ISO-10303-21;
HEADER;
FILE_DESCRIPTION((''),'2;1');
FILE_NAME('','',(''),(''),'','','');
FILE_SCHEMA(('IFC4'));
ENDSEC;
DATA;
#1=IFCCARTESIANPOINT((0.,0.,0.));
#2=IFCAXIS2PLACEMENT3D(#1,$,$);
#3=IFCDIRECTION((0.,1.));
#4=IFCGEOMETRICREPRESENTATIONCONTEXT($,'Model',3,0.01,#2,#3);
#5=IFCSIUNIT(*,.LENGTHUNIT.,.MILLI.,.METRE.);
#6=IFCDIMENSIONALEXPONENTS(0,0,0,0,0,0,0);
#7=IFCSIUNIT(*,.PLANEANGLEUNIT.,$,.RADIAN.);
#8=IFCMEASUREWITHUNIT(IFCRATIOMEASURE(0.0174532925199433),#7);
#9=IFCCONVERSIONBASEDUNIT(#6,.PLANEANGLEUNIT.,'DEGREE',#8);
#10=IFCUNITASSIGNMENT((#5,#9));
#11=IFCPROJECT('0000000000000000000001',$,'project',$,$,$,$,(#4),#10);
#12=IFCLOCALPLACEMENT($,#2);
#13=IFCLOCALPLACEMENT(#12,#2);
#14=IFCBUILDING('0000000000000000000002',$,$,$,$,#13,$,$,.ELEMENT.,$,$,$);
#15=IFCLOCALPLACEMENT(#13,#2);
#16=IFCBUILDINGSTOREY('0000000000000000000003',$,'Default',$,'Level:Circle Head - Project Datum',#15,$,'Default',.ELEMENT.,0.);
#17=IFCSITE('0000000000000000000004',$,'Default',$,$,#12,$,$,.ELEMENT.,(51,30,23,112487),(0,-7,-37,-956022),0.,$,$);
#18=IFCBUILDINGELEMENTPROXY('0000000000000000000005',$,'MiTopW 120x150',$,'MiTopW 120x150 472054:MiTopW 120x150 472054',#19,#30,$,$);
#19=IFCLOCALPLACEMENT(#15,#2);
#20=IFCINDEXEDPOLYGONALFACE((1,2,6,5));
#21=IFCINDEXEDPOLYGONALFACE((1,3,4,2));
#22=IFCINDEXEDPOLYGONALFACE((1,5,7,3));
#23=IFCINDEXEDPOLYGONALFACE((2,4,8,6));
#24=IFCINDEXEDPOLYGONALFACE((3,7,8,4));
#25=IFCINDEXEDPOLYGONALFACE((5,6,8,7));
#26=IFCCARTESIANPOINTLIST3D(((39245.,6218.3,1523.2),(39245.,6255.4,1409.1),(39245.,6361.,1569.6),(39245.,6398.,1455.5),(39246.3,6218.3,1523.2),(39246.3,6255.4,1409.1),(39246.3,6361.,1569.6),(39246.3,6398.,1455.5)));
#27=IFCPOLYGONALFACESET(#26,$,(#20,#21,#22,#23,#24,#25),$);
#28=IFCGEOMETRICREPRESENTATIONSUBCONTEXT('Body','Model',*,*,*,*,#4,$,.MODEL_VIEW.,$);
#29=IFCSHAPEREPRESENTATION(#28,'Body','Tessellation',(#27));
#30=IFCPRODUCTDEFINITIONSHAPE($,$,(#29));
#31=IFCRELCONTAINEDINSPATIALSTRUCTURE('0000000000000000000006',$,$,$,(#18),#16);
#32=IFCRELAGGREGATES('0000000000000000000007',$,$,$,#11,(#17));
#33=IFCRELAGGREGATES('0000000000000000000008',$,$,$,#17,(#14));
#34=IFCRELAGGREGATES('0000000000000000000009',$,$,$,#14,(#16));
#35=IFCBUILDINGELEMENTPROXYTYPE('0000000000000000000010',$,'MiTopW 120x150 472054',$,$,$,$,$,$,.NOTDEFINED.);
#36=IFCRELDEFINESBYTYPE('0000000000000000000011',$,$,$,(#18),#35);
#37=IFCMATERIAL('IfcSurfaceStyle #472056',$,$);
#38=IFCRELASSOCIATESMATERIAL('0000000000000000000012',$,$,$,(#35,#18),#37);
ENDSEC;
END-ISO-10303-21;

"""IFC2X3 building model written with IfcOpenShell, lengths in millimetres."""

from ifc_helpers import new_model, entity, si_unit, converted_unit, direction, frame, origin, place, context, subcontext, project, spatial, polyline, outline, extrude, source, transform, mapped, material, type_object, type_shapes, element, save


model = new_model("IFC2X3")

# Units and contexts
model_context = context("Model", 3, precision=0.01, world=origin(), true_north=direction((0.0, 1.0)))
body_context = subcontext(model_context, "Body", "Model", "MODEL_VIEW")
ifc_project = project(units=[si_unit("LENGTHUNIT", "METRE", prefix="MILLI"), converted_unit("PLANEANGLEUNIT", "DEGREE", entity("IfcRatioMeasure", 0.0174532925199433), si_unit("PLANEANGLEUNIT", "RADIAN"), dimensions=[0, 0, 0, 0, 0, 0, 0])], contexts=[model_context])

# Site, building, storey
site_placement = place(None, origin())
site = spatial("IfcSite", under=ifc_project, at=site_placement, Name="Default", CompositionType="ELEMENT", RefLatitude=(51, 30, 23, 112487), RefLongitude=(0, -7, -37, -956022), RefElevation=0.0)
building_placement = place(site_placement, origin())
building = spatial("IfcBuilding", under=site, at=building_placement, CompositionType="ELEMENT")
storey_placement = place(building_placement, origin())
storey = spatial("IfcBuildingStorey", under=building, at=storey_placement, Name="Default", ObjectType="Level:Circle Head - Project Datum", LongName="Default", CompositionType="ELEMENT", Elevation=0.0)

# Building element proxy
ifc_material_1 = material(Name="IfcSurfaceStyle #472056")
building_element_proxy_type_1 = type_object("IfcBuildingElementProxyType", Name="MiTopW 120x150 472054", PredefinedType="NOTDEFINED", material=ifc_material_1)
shared_shape_1 = source(origin(), body_context, "Body", "SweptSolid", [
    extrude(outline(polyline([(-75.0, -60.0), (75.0, -60.0), (75.0, 60.0), (-75.0, 60.0), (-75.0, -60.0)])), frame((75.0, 60.0, 0.0), z_axis=(0.0, 0.0, 1.0), x_axis=(-1.0, 0.0, 0.0)), (0.0, 0.0, 1.0), 1.3),
])
type_shapes(building_element_proxy_type_1, [shared_shape_1])
proxy_1_placement = place(building_placement, frame((39246.3, 6218.3, 1523.2), z_axis=(-1.0, 0.0, 0.0), x_axis=(0.0, 0.951057, 0.309017)))
element("IfcBuildingElementProxy", 1, at=proxy_1_placement, inside=storey, type_object=building_element_proxy_type_1, material=ifc_material_1, Name="MiTopW 120x150", ObjectType="MiTopW 120x150 472054:MiTopW 120x150 472054", context=body_context, shape_type="MappedRepresentation", body=[
    mapped(shared_shape_1, transform((0.0, 0.0, 0.0), scale=1.0)),
])

save(model, "model.ifc")
